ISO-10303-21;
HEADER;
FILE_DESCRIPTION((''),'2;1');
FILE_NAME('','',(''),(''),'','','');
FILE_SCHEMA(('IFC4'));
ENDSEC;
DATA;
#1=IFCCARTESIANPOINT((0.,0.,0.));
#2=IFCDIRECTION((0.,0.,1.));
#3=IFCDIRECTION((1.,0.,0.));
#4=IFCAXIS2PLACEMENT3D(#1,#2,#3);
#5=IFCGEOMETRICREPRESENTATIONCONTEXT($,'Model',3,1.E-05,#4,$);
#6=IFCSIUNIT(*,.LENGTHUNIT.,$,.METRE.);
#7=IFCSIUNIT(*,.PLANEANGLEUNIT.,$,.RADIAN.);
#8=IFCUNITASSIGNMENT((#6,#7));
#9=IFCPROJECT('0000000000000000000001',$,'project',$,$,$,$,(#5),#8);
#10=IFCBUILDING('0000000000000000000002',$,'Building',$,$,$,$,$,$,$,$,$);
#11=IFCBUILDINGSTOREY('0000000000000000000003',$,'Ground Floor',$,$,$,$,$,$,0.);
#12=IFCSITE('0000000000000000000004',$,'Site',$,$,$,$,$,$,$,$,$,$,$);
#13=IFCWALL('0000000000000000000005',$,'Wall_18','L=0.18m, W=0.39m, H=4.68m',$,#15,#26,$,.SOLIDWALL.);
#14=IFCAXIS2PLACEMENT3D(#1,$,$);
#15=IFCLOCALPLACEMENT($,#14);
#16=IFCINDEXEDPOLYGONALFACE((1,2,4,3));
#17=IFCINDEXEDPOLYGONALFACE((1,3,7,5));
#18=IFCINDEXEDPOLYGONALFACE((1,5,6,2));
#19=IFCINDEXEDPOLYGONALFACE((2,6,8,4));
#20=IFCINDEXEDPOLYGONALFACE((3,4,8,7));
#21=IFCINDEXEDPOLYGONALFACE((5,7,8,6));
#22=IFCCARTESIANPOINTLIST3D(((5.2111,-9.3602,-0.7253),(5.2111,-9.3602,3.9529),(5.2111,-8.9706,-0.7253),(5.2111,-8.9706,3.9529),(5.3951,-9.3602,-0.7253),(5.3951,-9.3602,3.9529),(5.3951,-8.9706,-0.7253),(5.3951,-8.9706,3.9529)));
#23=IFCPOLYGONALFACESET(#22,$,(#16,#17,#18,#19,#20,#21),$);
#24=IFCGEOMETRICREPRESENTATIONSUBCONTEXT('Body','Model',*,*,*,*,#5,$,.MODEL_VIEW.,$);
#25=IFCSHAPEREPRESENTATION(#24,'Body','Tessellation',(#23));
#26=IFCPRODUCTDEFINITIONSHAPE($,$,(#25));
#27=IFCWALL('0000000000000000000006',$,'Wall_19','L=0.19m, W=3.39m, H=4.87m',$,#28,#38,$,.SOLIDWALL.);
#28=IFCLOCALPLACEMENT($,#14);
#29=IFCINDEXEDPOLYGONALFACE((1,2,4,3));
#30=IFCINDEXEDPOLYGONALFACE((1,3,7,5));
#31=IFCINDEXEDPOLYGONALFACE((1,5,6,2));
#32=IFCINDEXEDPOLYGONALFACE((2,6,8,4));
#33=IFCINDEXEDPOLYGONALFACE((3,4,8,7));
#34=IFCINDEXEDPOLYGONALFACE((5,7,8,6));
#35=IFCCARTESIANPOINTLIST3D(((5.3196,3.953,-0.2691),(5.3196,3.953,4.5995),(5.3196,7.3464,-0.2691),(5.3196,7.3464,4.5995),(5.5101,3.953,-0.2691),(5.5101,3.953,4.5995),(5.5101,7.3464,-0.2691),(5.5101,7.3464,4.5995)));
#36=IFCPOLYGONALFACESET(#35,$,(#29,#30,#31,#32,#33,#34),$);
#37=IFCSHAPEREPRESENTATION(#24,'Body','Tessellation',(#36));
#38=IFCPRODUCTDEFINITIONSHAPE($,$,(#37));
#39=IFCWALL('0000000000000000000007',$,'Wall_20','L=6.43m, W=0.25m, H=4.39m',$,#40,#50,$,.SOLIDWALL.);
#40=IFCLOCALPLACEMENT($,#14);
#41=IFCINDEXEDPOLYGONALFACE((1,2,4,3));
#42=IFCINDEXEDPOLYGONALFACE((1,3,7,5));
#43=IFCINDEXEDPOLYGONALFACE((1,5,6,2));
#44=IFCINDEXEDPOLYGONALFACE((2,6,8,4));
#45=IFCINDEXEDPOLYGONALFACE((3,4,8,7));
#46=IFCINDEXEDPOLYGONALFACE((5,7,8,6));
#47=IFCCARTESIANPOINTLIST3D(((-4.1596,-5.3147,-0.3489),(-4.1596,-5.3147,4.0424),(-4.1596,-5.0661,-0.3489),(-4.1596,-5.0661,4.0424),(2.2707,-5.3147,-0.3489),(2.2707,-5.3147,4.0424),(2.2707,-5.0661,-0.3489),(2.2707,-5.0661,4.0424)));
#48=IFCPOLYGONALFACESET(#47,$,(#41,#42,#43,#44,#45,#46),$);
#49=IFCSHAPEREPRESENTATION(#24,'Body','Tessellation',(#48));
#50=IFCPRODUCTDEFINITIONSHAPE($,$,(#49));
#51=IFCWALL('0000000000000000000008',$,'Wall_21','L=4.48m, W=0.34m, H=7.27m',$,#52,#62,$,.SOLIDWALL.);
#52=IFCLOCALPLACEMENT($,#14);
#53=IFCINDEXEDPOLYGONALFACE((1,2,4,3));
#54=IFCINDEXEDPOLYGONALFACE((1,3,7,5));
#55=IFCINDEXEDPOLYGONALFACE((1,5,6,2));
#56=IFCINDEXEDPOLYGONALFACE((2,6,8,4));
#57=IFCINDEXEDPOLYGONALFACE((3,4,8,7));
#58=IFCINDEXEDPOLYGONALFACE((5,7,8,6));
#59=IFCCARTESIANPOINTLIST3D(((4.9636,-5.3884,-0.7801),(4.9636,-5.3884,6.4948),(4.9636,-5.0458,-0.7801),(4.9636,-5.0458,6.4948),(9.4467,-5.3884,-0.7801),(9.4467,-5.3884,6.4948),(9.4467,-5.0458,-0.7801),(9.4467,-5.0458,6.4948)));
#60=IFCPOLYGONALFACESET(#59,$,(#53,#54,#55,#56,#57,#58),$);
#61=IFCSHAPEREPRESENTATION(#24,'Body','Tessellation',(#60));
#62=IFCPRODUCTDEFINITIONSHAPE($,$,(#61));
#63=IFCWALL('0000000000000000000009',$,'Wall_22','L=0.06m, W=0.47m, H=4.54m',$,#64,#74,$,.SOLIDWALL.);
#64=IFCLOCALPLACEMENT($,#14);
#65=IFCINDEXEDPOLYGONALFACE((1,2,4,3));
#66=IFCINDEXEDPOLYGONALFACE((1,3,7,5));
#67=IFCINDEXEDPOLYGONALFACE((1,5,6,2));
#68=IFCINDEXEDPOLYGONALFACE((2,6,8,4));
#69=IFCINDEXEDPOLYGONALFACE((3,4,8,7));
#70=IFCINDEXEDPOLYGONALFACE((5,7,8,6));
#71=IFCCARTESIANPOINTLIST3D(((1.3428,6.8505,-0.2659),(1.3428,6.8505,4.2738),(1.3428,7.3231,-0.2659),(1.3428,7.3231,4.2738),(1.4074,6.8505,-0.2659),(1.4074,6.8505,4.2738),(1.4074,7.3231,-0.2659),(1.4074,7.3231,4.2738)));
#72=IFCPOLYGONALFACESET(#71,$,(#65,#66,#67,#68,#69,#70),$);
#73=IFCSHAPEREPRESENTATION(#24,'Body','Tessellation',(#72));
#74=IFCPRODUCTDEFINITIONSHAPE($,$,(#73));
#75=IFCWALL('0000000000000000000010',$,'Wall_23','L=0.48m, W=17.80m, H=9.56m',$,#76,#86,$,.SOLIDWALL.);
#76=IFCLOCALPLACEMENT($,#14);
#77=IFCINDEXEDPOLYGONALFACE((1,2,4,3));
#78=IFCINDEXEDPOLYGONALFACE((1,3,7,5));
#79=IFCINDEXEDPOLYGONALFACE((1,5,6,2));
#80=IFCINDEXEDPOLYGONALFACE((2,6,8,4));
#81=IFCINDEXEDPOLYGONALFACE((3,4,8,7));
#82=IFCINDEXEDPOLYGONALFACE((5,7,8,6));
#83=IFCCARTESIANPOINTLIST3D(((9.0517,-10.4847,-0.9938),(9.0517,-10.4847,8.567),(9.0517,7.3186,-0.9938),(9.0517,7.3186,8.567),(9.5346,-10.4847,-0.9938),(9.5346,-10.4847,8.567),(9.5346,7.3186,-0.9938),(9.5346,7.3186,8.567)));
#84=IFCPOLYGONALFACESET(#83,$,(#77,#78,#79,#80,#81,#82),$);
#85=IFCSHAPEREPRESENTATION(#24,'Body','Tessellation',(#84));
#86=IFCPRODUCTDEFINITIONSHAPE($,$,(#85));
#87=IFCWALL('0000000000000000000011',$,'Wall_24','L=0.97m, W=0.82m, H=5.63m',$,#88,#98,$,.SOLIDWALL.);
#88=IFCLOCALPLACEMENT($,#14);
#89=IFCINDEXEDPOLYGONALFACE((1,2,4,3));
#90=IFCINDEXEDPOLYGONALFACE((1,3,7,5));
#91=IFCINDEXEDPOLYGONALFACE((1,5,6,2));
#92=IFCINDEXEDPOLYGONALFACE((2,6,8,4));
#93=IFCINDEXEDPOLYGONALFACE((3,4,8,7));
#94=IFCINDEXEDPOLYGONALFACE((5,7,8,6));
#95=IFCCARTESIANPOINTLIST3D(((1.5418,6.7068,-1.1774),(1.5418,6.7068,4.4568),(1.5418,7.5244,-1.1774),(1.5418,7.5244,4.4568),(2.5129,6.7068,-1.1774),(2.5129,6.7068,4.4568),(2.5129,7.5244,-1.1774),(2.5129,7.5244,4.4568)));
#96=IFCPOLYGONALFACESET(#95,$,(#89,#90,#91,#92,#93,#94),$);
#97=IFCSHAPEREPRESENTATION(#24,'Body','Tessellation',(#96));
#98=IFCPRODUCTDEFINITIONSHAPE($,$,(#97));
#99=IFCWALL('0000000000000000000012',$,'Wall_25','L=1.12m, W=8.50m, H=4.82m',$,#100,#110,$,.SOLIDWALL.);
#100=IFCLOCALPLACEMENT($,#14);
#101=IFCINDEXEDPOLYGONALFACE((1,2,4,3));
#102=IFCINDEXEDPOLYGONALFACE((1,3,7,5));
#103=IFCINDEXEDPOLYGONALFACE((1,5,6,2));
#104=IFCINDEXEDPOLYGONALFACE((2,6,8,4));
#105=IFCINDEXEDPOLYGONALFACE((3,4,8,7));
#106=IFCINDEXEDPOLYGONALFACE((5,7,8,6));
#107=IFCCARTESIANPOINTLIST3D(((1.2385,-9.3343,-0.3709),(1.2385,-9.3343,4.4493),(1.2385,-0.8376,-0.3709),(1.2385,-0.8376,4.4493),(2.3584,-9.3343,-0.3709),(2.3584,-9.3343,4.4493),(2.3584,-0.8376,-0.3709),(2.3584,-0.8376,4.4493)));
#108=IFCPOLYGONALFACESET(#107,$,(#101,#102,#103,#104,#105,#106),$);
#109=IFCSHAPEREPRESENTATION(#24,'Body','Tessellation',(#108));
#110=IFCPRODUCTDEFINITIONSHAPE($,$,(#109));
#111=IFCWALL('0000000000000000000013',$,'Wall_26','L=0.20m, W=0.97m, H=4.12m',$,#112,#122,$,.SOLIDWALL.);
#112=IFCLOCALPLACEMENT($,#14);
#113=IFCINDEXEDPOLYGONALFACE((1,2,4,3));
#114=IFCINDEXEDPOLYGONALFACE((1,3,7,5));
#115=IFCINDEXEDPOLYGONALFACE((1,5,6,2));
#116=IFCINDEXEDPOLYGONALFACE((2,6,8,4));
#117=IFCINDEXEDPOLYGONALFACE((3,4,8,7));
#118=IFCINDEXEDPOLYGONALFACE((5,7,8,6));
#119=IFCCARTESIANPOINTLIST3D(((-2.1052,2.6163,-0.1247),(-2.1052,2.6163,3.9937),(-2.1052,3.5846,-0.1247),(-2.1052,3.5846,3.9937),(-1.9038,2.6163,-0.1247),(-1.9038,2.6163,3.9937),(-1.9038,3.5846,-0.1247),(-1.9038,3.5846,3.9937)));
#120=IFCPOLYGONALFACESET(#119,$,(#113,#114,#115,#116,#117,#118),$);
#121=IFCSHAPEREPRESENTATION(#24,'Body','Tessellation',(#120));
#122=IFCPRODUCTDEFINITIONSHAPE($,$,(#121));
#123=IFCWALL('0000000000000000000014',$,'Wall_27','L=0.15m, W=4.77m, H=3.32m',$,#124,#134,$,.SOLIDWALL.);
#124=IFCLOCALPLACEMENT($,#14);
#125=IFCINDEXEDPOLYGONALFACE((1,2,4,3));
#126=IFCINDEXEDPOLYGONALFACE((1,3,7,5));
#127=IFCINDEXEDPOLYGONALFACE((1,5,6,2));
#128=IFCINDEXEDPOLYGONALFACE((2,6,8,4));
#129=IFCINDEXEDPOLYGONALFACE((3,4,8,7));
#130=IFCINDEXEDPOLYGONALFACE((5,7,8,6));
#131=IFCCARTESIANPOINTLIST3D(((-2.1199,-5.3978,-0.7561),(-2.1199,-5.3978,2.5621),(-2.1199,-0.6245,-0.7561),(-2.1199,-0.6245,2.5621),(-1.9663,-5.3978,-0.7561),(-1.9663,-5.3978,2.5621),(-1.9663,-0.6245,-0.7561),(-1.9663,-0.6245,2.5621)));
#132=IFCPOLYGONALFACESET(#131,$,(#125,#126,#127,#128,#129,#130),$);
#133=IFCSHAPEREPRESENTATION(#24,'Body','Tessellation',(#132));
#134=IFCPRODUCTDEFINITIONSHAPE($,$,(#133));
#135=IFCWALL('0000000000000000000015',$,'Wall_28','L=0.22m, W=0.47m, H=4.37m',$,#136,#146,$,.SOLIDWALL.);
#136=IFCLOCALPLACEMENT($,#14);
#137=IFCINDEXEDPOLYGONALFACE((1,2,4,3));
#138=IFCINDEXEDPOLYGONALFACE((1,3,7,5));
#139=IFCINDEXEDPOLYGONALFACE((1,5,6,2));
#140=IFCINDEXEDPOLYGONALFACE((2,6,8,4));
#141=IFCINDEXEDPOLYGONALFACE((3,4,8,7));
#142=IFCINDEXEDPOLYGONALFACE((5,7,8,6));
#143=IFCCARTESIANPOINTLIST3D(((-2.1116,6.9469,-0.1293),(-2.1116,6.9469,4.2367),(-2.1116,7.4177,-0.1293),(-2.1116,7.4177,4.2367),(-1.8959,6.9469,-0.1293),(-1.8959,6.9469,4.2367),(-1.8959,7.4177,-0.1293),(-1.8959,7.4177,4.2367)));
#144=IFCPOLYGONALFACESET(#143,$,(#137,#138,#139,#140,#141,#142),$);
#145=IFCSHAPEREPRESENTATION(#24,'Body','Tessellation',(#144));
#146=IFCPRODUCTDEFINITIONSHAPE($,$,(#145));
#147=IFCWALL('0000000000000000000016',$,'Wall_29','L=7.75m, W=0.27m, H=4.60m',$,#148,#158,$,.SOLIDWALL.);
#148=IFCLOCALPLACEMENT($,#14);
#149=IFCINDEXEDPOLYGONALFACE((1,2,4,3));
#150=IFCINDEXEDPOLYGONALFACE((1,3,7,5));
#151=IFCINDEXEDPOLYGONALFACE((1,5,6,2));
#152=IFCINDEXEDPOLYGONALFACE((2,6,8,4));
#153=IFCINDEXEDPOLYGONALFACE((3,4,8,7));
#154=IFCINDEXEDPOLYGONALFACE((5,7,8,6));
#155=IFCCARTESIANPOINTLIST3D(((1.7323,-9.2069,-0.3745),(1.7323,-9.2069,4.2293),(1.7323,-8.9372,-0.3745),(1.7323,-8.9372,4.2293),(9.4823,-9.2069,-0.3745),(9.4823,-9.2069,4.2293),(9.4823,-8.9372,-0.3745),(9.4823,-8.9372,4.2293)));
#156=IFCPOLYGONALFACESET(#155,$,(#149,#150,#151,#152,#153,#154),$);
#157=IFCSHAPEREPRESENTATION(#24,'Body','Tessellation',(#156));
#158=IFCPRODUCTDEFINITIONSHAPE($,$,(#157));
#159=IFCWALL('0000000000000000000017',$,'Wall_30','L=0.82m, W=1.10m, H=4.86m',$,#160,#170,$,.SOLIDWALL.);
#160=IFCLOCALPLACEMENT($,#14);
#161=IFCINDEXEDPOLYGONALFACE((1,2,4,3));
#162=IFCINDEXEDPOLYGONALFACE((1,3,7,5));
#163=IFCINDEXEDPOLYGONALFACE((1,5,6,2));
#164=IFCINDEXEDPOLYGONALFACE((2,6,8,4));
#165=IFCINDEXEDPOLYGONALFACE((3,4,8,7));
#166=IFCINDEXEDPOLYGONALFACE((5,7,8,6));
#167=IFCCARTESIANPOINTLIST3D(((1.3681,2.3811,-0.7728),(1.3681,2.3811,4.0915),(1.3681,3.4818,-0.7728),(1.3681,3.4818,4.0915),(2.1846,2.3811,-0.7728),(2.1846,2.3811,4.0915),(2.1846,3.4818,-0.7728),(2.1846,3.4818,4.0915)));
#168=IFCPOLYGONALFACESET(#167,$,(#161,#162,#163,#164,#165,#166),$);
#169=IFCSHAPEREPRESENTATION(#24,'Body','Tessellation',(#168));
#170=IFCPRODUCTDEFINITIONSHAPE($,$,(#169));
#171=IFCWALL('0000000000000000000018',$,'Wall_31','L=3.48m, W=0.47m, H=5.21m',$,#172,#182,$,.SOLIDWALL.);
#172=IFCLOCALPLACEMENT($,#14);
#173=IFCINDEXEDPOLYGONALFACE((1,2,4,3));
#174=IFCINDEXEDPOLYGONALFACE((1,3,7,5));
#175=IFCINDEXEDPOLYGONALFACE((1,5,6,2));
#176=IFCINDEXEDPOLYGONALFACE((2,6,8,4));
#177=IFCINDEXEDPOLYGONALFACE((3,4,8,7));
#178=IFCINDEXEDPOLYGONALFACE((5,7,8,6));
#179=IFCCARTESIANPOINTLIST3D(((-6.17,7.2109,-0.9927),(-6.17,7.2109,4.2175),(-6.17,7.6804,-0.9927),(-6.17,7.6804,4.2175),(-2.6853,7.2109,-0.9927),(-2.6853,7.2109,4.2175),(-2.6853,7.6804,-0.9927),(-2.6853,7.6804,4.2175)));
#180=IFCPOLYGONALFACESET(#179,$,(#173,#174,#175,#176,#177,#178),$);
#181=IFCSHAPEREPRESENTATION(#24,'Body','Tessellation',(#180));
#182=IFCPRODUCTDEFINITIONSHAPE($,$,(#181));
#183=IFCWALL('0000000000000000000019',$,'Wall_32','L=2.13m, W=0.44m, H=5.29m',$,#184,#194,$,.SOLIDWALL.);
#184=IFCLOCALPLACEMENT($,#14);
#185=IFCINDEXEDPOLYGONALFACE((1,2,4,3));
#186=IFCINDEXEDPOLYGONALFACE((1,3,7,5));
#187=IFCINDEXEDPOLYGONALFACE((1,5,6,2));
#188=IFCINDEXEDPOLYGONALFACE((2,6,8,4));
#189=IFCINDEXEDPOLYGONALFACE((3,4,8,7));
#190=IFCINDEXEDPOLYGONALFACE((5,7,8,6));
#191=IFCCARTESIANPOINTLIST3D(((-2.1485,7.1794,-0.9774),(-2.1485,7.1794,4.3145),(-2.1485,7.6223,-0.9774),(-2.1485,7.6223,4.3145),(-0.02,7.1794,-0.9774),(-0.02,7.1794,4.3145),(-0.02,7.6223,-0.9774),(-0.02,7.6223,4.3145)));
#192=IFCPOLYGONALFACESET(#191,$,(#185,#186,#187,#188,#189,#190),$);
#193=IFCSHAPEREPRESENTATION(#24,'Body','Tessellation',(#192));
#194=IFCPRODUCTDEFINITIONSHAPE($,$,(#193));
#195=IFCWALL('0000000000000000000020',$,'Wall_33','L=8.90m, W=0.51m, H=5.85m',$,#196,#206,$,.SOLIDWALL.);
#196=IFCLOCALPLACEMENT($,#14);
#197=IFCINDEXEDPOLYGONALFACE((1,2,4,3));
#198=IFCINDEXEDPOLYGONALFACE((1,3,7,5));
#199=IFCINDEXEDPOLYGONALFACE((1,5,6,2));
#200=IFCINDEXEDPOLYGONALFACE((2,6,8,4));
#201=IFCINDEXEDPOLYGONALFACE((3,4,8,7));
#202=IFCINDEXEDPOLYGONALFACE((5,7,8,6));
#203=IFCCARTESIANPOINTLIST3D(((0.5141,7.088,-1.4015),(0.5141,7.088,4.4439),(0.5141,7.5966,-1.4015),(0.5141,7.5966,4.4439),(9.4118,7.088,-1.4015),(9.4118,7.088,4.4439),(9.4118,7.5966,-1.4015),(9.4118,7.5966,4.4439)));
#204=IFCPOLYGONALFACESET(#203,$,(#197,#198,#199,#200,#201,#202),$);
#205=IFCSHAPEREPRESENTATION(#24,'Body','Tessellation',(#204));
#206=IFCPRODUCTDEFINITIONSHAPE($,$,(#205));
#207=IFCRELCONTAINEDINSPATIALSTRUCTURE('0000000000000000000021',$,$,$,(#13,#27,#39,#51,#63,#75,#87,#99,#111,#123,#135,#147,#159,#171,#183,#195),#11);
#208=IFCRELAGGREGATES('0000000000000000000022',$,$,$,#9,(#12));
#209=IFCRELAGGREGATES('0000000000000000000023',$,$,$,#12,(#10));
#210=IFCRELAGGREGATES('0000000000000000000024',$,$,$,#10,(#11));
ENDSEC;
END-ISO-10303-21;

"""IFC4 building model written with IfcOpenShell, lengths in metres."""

from ifc_helpers import new_model, si_unit, frame, origin_with_axes, origin_2d, context, subcontext, project, spatial, rectangle, extrude, element, save


model = new_model("IFC4")

# Units and contexts
model_context = context("Model", 3, precision=1e-05, world=origin_with_axes())
body_context = subcontext(model_context, "Body", "Model", "MODEL_VIEW")
ifc_project = project(units=[si_unit("LENGTHUNIT", "METRE"), si_unit("PLANEANGLEUNIT", "RADIAN")], contexts=[model_context])

# Site, building, storey
site = spatial("IfcSite", under=ifc_project, Name="Site")
building = spatial("IfcBuilding", under=site, Name="Building")
storey = spatial("IfcBuildingStorey", under=building, Name="Ground Floor", Elevation=0.0)

# Walls
element("IfcWall", 1, inside=storey, Name="Wall_18", Description="L=0.18m, W=0.39m, H=4.68m", PredefinedType="SOLIDWALL", context=body_context, shape_type="SweptSolid", body=[
    extrude(rectangle(XDim=0.184, YDim=0.3896, at=origin_2d()), frame((5.3031, -9.1654, -0.7253), z_axis=(0.0, 0.0, 1.0), x_axis=(1.0, 0.0, 0.0)), (0.0, 0.0, 1.0), 4.6782),
])
element("IfcWall", 2, inside=storey, Name="Wall_19", Description="L=0.19m, W=3.39m, H=4.87m", PredefinedType="SOLIDWALL", context=body_context, shape_type="SweptSolid", body=[
    extrude(rectangle(XDim=0.1906, YDim=3.3933, at=origin_2d()), frame((5.4148, 5.6497, -0.2691), z_axis=(0.0, 0.0, 1.0), x_axis=(1.0, 0.0, 0.0)), (0.0, 0.0, 1.0), 4.8686),
])
element("IfcWall", 3, inside=storey, Name="Wall_20", Description="L=6.43m, W=0.25m, H=4.39m", PredefinedType="SOLIDWALL", context=body_context, shape_type="SweptSolid", body=[
    extrude(rectangle(XDim=6.4303, YDim=0.2487, at=origin_2d()), frame((-0.9445, -5.1904, -0.3489), z_axis=(0.0, 0.0, 1.0), x_axis=(1.0, 0.0, 0.0)), (0.0, 0.0, 1.0), 4.3913),
])
element("IfcWall", 4, inside=storey, Name="Wall_21", Description="L=4.48m, W=0.34m, H=7.27m", PredefinedType="SOLIDWALL", context=body_context, shape_type="SweptSolid", body=[
    extrude(rectangle(XDim=4.4831, YDim=0.3426, at=origin_2d()), frame((7.2052, -5.2171, -0.7801), z_axis=(0.0, 0.0, 1.0), x_axis=(1.0, 0.0, 0.0)), (0.0, 0.0, 1.0), 7.2749),
])
element("IfcWall", 5, inside=storey, Name="Wall_22", Description="L=0.06m, W=0.47m, H=4.54m", PredefinedType="SOLIDWALL", context=body_context, shape_type="SweptSolid", body=[
    extrude(rectangle(XDim=0.0646, YDim=0.4726, at=origin_2d()), frame((1.3751, 7.0868, -0.2659), z_axis=(0.0, 0.0, 1.0), x_axis=(1.0, 0.0, 0.0)), (0.0, 0.0, 1.0), 4.5397),
])
element("IfcWall", 6, inside=storey, Name="Wall_23", Description="L=0.48m, W=17.80m, H=9.56m", PredefinedType="SOLIDWALL", context=body_context, shape_type="SweptSolid", body=[
    extrude(rectangle(XDim=0.483, YDim=17.8033, at=origin_2d()), frame((9.2931, -1.5831, -0.9938), z_axis=(0.0, 0.0, 1.0), x_axis=(1.0, 0.0, 0.0)), (0.0, 0.0, 1.0), 9.5608),
])
element("IfcWall", 7, inside=storey, Name="Wall_24", Description="L=0.97m, W=0.82m, H=5.63m", PredefinedType="SOLIDWALL", context=body_context, shape_type="SweptSolid", body=[
    extrude(rectangle(XDim=0.9711, YDim=0.8176, at=origin_2d()), frame((2.0273, 7.1156, -1.1774), z_axis=(0.0, 0.0, 1.0), x_axis=(1.0, 0.0, 0.0)), (0.0, 0.0, 1.0), 5.6342),
])
element("IfcWall", 8, inside=storey, Name="Wall_25", Description="L=1.12m, W=8.50m, H=4.82m", PredefinedType="SOLIDWALL", context=body_context, shape_type="SweptSolid", body=[
    extrude(rectangle(XDim=1.1199, YDim=8.4967, at=origin_2d()), frame((1.7984, -5.086, -0.3709), z_axis=(0.0, 0.0, 1.0), x_axis=(1.0, 0.0, 0.0)), (0.0, 0.0, 1.0), 4.8202),
])
element("IfcWall", 9, inside=storey, Name="Wall_26", Description="L=0.20m, W=0.97m, H=4.12m", PredefinedType="SOLIDWALL", context=body_context, shape_type="SweptSolid", body=[
    extrude(rectangle(XDim=0.2014, YDim=0.9684, at=origin_2d()), frame((-2.0045, 3.1005, -0.1247), z_axis=(0.0, 0.0, 1.0), x_axis=(1.0, 0.0, 0.0)), (0.0, 0.0, 1.0), 4.1184),
])
element("IfcWall", 10, inside=storey, Name="Wall_27", Description="L=0.15m, W=4.77m, H=3.32m", PredefinedType="SOLIDWALL", context=body_context, shape_type="SweptSolid", body=[
    extrude(rectangle(XDim=0.1537, YDim=4.7733, at=origin_2d()), frame((-2.0431, -3.0111, -0.7561), z_axis=(0.0, 0.0, 1.0), x_axis=(1.0, 0.0, 0.0)), (0.0, 0.0, 1.0), 3.3182),
])
element("IfcWall", 11, inside=storey, Name="Wall_28", Description="L=0.22m, W=0.47m, H=4.37m", PredefinedType="SOLIDWALL", context=body_context, shape_type="SweptSolid", body=[
    extrude(rectangle(XDim=0.2157, YDim=0.4708, at=origin_2d()), frame((-2.0037, 7.1823, -0.1293), z_axis=(0.0, 0.0, 1.0), x_axis=(1.0, 0.0, 0.0)), (0.0, 0.0, 1.0), 4.366),
])
element("IfcWall", 12, inside=storey, Name="Wall_29", Description="L=7.75m, W=0.27m, H=4.60m", PredefinedType="SOLIDWALL", context=body_context, shape_type="SweptSolid", body=[
    extrude(rectangle(XDim=7.7499, YDim=0.2697, at=origin_2d()), frame((5.6073, -9.072, -0.3745), z_axis=(0.0, 0.0, 1.0), x_axis=(1.0, 0.0, 0.0)), (0.0, 0.0, 1.0), 4.6038),
])
element("IfcWall", 13, inside=storey, Name="Wall_30", Description="L=0.82m, W=1.10m, H=4.86m", PredefinedType="SOLIDWALL", context=body_context, shape_type="SweptSolid", body=[
    extrude(rectangle(XDim=0.8165, YDim=1.1007, at=origin_2d()), frame((1.7764, 2.9314, -0.7728), z_axis=(0.0, 0.0, 1.0), x_axis=(1.0, 0.0, 0.0)), (0.0, 0.0, 1.0), 4.8643),
])
element("IfcWall", 14, inside=storey, Name="Wall_31", Description="L=3.48m, W=0.47m, H=5.21m", PredefinedType="SOLIDWALL", context=body_context, shape_type="SweptSolid", body=[
    extrude(rectangle(XDim=3.4847, YDim=0.4695, at=origin_2d()), frame((-4.4276, 7.4457, -0.9927), z_axis=(0.0, 0.0, 1.0), x_axis=(1.0, 0.0, 0.0)), (0.0, 0.0, 1.0), 5.2102),
])
element("IfcWall", 15, inside=storey, Name="Wall_32", Description="L=2.13m, W=0.44m, H=5.29m", PredefinedType="SOLIDWALL", context=body_context, shape_type="SweptSolid", body=[
    extrude(rectangle(XDim=2.1285, YDim=0.4429, at=origin_2d()), frame((-1.0842, 7.4009, -0.9774), z_axis=(0.0, 0.0, 1.0), x_axis=(1.0, 0.0, 0.0)), (0.0, 0.0, 1.0), 5.2919),
])
element("IfcWall", 16, inside=storey, Name="Wall_33", Description="L=8.90m, W=0.51m, H=5.85m", PredefinedType="SOLIDWALL", context=body_context, shape_type="SweptSolid", body=[
    extrude(rectangle(XDim=8.8977, YDim=0.5085, at=origin_2d()), frame((4.9629, 7.3423, -1.4015), z_axis=(0.0, 0.0, 1.0), x_axis=(1.0, 0.0, 0.0)), (0.0, 0.0, 1.0), 5.8454),
])

save(model, "model.ifc")
